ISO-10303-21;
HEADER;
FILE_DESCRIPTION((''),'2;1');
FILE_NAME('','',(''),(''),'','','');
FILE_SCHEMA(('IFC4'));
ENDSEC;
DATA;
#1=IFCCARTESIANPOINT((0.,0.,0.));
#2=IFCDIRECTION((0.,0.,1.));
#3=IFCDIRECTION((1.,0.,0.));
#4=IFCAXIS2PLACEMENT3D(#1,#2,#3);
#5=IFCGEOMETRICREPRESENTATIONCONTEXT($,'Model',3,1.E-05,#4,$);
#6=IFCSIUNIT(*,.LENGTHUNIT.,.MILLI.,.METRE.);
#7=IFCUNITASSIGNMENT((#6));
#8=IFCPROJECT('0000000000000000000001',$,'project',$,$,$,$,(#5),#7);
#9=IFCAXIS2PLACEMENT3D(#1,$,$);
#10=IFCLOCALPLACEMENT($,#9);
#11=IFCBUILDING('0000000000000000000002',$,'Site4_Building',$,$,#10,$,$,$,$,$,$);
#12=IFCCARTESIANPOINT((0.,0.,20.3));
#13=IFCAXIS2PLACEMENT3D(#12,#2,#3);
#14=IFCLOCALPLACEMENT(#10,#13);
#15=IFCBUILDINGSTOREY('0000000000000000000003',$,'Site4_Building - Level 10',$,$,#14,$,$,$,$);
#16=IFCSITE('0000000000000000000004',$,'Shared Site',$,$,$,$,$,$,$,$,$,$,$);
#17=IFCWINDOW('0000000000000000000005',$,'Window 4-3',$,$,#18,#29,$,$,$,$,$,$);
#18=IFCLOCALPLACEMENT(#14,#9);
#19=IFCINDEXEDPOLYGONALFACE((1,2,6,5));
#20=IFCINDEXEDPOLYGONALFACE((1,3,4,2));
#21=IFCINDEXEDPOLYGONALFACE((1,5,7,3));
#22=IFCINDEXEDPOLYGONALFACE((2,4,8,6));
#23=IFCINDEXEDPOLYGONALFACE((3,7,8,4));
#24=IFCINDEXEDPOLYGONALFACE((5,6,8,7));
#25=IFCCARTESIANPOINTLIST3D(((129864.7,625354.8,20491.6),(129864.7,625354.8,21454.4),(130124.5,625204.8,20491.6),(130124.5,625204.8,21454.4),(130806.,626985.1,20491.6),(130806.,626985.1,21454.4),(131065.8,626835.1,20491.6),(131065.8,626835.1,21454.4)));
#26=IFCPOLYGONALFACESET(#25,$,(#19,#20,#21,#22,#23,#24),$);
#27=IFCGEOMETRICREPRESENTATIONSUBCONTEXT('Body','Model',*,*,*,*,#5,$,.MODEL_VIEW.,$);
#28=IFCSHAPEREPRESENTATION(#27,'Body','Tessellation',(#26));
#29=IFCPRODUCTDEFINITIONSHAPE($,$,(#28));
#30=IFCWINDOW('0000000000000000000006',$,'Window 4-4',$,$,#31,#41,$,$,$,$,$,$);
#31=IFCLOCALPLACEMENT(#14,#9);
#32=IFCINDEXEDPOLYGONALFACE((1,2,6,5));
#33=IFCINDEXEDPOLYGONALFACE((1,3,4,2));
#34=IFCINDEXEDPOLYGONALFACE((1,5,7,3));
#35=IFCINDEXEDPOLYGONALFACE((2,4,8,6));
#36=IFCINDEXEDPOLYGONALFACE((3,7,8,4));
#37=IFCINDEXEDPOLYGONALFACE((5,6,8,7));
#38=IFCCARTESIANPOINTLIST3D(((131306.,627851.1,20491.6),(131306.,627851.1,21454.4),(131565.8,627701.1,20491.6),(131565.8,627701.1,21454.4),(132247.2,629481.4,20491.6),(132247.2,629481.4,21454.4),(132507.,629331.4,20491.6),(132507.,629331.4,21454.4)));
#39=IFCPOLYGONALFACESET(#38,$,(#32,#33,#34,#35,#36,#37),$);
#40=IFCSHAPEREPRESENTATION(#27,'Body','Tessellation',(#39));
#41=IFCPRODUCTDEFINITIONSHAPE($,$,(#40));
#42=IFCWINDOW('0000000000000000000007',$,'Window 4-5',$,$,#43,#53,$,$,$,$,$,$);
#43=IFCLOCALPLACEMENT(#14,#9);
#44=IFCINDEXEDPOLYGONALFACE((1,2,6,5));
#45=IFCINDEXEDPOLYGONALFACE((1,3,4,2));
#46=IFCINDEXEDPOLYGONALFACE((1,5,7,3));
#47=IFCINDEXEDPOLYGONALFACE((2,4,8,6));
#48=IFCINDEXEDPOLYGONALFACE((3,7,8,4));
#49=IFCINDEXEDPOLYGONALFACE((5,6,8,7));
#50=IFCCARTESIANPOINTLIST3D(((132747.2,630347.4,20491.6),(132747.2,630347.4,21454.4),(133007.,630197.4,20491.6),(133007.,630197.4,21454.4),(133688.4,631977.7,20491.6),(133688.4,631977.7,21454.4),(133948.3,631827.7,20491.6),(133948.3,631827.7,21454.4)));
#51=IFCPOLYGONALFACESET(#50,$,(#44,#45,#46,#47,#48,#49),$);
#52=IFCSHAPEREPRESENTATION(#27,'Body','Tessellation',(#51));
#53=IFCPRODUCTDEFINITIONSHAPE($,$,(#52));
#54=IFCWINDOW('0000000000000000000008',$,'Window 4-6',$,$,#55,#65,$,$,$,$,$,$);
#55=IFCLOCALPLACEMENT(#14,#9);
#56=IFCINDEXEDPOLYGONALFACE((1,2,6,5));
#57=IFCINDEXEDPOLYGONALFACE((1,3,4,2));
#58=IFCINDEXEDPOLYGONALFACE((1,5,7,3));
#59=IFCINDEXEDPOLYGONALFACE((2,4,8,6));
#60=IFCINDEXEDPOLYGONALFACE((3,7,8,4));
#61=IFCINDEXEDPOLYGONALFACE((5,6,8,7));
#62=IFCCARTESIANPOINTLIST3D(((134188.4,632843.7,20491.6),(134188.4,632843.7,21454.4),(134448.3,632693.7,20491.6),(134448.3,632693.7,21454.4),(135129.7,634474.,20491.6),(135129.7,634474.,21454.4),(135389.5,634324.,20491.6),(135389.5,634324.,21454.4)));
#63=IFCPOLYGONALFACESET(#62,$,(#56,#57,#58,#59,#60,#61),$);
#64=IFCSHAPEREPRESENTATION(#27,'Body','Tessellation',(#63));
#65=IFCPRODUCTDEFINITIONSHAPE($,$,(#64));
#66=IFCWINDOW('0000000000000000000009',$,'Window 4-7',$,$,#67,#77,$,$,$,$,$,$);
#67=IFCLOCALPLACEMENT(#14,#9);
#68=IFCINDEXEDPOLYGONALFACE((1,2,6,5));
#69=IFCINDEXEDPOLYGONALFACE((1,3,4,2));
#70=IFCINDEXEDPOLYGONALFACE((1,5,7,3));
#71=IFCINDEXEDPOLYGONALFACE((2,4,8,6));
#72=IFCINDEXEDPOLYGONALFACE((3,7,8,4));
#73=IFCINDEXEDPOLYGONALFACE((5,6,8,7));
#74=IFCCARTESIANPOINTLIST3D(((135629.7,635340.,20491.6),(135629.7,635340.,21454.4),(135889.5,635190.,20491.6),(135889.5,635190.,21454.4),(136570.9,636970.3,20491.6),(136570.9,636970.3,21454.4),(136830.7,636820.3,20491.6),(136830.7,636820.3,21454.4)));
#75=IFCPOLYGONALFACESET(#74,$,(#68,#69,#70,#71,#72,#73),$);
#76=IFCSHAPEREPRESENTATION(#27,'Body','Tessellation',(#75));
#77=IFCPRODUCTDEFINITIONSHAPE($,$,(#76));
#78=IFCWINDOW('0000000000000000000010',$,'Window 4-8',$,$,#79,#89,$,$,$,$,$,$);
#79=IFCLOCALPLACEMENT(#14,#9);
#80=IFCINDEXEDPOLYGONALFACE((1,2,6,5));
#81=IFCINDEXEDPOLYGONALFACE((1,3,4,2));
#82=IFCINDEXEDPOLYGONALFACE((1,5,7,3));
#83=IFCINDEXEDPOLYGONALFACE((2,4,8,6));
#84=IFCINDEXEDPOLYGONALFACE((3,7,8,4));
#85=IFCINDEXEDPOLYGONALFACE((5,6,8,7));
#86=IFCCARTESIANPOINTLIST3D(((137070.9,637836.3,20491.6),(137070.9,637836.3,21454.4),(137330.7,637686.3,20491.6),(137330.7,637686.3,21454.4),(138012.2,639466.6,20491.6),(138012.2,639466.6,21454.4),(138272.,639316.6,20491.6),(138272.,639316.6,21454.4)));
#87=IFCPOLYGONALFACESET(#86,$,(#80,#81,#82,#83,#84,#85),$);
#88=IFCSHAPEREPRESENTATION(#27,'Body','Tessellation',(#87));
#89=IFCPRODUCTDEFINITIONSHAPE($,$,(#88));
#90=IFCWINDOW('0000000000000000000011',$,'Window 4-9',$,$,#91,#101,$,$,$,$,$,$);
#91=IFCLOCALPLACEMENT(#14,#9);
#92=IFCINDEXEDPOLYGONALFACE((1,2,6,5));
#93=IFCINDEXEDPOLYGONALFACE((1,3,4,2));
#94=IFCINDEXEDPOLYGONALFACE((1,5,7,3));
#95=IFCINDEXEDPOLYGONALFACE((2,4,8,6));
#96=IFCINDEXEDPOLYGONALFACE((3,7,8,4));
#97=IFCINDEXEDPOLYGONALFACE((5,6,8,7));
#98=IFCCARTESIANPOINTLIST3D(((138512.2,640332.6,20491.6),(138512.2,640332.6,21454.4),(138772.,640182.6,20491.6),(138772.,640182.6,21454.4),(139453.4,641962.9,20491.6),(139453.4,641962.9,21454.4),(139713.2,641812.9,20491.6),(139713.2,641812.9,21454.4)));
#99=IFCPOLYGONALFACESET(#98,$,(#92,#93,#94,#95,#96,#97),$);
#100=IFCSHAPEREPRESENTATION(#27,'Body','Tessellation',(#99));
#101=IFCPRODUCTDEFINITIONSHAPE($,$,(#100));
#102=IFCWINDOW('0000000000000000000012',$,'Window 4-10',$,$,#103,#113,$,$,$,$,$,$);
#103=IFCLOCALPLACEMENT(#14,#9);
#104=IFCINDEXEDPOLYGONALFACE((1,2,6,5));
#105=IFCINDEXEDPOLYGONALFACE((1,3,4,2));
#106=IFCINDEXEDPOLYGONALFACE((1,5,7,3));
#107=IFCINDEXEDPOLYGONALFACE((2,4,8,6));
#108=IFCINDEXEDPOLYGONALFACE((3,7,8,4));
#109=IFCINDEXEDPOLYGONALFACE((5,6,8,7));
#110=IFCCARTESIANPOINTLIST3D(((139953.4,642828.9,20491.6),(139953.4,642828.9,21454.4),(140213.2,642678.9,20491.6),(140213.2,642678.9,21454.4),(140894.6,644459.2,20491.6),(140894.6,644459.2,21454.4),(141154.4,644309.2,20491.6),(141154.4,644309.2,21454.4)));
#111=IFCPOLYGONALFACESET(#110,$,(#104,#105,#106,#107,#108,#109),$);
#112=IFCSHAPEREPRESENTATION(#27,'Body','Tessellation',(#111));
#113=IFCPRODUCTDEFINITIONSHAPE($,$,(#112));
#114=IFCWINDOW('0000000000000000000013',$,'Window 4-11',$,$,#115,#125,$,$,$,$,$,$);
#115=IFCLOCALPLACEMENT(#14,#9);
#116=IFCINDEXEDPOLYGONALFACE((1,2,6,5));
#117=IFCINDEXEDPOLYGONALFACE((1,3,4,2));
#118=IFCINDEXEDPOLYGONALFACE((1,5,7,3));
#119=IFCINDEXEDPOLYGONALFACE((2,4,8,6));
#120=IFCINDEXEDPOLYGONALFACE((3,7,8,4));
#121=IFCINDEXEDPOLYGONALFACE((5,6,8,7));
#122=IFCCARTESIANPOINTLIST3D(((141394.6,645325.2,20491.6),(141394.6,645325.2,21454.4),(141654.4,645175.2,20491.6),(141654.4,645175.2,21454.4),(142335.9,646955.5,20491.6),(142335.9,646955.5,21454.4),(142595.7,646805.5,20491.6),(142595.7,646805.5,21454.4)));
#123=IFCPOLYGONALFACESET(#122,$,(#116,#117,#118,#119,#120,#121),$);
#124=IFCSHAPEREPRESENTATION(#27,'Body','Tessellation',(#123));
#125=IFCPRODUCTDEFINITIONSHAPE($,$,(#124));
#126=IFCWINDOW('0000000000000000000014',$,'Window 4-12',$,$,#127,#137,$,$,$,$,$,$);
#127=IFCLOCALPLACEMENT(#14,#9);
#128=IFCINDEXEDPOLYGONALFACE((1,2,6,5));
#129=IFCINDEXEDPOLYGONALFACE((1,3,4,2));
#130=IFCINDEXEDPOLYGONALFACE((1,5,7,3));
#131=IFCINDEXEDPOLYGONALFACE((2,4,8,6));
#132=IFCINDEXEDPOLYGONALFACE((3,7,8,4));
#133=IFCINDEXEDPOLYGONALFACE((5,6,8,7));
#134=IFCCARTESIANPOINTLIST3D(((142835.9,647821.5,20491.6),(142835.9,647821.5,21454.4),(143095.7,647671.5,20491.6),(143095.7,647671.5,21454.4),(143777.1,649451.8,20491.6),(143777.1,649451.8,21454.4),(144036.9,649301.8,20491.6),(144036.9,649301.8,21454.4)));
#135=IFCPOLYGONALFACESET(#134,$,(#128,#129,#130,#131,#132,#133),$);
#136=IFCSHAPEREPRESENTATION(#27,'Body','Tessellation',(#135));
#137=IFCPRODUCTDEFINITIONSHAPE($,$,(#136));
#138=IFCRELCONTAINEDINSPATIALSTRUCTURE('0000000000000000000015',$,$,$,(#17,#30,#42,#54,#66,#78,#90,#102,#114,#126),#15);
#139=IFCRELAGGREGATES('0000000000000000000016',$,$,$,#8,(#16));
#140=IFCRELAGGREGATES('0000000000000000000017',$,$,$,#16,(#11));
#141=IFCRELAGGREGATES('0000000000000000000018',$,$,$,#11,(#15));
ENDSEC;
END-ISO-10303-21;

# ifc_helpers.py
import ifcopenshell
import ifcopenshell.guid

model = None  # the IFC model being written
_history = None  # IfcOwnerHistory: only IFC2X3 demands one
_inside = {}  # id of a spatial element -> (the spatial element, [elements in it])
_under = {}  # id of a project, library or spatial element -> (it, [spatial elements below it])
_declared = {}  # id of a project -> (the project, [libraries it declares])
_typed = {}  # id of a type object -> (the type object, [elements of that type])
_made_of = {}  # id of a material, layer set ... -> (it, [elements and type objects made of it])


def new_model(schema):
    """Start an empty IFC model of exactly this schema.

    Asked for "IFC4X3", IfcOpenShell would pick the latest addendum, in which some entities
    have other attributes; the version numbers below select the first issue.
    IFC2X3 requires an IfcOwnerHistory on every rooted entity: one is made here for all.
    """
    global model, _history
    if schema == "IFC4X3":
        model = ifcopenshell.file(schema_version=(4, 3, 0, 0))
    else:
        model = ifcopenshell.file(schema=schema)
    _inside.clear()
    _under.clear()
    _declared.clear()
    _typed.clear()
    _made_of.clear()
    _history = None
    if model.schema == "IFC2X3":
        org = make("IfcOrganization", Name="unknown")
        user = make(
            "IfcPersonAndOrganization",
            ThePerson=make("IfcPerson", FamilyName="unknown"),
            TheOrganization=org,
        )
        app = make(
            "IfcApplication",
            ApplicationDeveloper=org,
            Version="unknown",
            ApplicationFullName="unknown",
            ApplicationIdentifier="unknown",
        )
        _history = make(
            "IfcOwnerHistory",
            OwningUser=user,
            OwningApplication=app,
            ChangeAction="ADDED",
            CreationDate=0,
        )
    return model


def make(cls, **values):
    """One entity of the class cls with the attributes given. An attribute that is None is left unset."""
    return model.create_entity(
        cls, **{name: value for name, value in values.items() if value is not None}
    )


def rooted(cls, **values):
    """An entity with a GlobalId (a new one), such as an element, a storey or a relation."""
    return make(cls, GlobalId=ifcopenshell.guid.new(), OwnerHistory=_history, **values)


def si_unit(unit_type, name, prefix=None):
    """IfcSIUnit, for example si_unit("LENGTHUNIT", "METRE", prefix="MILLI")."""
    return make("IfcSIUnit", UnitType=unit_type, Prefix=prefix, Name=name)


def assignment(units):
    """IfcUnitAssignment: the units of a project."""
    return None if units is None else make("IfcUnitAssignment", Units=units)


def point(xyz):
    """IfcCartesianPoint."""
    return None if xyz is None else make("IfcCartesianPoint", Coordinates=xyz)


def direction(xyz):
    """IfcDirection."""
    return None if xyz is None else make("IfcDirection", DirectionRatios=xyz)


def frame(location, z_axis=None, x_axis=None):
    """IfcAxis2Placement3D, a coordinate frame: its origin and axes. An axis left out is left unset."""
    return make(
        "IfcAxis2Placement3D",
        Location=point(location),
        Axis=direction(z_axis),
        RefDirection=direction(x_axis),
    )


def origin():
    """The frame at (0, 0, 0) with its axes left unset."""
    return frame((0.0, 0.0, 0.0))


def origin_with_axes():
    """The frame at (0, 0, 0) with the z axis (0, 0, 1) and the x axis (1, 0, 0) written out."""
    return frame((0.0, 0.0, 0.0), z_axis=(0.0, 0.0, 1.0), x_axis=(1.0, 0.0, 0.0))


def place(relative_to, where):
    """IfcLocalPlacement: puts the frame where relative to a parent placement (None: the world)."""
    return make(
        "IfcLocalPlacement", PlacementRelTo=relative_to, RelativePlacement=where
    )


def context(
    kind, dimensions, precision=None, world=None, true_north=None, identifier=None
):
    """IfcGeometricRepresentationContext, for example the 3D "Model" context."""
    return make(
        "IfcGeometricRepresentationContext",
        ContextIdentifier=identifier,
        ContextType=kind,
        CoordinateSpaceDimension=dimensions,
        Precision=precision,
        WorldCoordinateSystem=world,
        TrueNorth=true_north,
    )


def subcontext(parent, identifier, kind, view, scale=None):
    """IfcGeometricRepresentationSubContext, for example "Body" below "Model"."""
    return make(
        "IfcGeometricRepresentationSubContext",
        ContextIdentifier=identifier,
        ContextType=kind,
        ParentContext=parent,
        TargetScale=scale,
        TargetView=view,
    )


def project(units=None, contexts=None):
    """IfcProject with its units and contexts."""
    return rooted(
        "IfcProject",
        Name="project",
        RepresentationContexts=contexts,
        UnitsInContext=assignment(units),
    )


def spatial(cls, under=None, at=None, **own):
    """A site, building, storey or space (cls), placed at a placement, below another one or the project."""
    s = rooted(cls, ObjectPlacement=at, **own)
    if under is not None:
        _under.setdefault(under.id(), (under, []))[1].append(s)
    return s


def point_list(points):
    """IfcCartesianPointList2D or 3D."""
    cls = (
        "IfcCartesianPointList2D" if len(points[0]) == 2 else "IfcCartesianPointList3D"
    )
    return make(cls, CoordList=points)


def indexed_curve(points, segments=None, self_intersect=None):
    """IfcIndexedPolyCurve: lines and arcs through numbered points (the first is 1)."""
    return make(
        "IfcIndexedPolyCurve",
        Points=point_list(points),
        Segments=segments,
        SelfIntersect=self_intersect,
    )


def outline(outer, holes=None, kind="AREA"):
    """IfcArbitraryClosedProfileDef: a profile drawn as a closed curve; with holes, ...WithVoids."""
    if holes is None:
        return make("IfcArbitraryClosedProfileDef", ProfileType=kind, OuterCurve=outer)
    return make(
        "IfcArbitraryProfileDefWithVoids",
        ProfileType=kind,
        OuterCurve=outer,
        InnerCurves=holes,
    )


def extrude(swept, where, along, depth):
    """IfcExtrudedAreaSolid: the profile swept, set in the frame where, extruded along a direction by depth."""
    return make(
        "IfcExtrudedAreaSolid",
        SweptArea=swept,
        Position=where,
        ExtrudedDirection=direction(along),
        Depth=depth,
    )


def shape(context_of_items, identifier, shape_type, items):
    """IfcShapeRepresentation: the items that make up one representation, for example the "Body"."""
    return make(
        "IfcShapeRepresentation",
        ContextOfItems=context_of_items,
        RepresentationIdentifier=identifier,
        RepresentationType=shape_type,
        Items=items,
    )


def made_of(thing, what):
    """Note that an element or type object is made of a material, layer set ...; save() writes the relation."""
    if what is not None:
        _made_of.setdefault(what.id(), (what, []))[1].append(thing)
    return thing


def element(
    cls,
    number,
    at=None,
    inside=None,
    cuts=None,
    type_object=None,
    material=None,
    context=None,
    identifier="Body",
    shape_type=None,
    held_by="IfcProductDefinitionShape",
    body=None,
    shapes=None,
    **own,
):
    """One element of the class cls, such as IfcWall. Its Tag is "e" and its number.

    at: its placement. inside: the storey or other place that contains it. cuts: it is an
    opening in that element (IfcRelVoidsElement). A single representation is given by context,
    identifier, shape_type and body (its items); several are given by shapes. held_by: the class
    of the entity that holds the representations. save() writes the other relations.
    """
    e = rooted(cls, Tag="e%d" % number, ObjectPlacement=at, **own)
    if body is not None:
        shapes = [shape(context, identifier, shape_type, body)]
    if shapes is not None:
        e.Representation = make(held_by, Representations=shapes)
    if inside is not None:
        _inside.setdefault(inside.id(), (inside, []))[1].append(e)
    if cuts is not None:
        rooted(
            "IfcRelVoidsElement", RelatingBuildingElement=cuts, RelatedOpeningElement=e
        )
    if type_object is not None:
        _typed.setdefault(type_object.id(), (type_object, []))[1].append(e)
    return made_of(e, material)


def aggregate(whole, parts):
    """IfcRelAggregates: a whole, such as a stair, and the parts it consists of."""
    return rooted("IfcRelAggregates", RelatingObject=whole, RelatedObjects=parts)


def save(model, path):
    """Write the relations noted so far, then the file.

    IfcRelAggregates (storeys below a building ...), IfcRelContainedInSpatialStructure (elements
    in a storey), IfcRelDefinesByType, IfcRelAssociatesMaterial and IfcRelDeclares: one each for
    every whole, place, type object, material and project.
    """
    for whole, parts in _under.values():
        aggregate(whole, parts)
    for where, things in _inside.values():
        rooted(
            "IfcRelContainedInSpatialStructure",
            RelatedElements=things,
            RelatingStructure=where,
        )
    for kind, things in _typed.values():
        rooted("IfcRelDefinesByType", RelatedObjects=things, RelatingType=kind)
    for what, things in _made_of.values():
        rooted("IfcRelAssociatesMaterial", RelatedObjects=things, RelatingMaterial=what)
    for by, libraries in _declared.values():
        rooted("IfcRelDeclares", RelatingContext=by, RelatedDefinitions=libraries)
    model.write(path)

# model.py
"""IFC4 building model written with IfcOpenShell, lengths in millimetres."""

from ifc_helpers import new_model, si_unit, frame, origin, origin_with_axes, place, context, subcontext, project, spatial, indexed_curve, outline, extrude, element, save


model = new_model("IFC4")

# Units and contexts
model_context = context("Model", 3, precision=1e-05, world=origin_with_axes())
body_context = subcontext(model_context, "Body", "Model", "MODEL_VIEW")
ifc_project = project(units=[si_unit("LENGTHUNIT", "METRE", prefix="MILLI")], contexts=[model_context])

# Site, building, storey
site = spatial("IfcSite", under=ifc_project, Name="Shared Site")
building_placement = place(None, origin())
building = spatial("IfcBuilding", under=site, at=building_placement, Name="Site4_Building")
storey_placement = place(building_placement, frame((0.0, 0.0, 20.3), z_axis=(0.0, 0.0, 1.0), x_axis=(1.0, 0.0, 0.0)))
storey = spatial("IfcBuildingStorey", under=building, at=storey_placement, Name="Site4_Building - Level 10")

# Windows
for number, where, z_axis, x_axis, name in (
    (1, (130124.5, 625204.8, 20491.6), (0.0, 0.0, 1.0), (0.5, 0.866025, 0.0), "Window 4-3"),
    (2, (131565.8, 627701.1, 20491.6), (0.0, 0.0, 1.0), (0.5, 0.866025, 0.0), "Window 4-4"),
    (3, (133007.0, 630197.4, 20491.6), (0.0, 0.0, 1.0), (0.5, 0.866025, 0.0), "Window 4-5"),
    (4, (134448.3, 632693.7, 20491.6), (0.0, 0.0, 1.0), (0.5, 0.866025, 0.0), "Window 4-6"),
    (5, (135889.5, 635190.0, 20491.6), (0.0, 0.0, 1.0), (0.5, 0.866025, 0.0), "Window 4-7"),
    (6, (137330.7, 637686.3, 20491.6), (0.0, 0.0, 1.0), (0.5, 0.866025, 0.0), "Window 4-8"),
    (7, (138772.0, 640182.6, 20491.6), (0.0, 0.0, 1.0), (0.5, 0.866025, 0.0), "Window 4-9"),
    (8, (140213.2, 642678.9, 20491.6), (0.0, 0.0, 1.0), (0.5, 0.866025, 0.0), "Window 4-10"),
    (9, (141654.4, 645175.2, 20491.6), (0.0, 0.0, 1.0), (0.5, 0.866025, 0.0), "Window 4-11"),
    (10, (143095.7, 647671.5, 20491.6), (0.0, 0.0, 1.0), (0.5, 0.866025, 0.0), "Window 4-12"),
):
    element("IfcWindow", number, at=place(storey_placement, frame(where, z_axis=z_axis, x_axis=x_axis)), inside=storey, Name=name, context=body_context, shape_type="SweptSolid", body=[
        extrude(outline(indexed_curve([(0.0, 0.0), (0.0, 300.0), (1882.5, 300.0), (1882.5, 0.0), (0.0, 0.0)], self_intersect=False)), origin_with_axes(), (0.0, 0.0, 1.0), 962.8),
    ])

save(model, "model.ifc")
